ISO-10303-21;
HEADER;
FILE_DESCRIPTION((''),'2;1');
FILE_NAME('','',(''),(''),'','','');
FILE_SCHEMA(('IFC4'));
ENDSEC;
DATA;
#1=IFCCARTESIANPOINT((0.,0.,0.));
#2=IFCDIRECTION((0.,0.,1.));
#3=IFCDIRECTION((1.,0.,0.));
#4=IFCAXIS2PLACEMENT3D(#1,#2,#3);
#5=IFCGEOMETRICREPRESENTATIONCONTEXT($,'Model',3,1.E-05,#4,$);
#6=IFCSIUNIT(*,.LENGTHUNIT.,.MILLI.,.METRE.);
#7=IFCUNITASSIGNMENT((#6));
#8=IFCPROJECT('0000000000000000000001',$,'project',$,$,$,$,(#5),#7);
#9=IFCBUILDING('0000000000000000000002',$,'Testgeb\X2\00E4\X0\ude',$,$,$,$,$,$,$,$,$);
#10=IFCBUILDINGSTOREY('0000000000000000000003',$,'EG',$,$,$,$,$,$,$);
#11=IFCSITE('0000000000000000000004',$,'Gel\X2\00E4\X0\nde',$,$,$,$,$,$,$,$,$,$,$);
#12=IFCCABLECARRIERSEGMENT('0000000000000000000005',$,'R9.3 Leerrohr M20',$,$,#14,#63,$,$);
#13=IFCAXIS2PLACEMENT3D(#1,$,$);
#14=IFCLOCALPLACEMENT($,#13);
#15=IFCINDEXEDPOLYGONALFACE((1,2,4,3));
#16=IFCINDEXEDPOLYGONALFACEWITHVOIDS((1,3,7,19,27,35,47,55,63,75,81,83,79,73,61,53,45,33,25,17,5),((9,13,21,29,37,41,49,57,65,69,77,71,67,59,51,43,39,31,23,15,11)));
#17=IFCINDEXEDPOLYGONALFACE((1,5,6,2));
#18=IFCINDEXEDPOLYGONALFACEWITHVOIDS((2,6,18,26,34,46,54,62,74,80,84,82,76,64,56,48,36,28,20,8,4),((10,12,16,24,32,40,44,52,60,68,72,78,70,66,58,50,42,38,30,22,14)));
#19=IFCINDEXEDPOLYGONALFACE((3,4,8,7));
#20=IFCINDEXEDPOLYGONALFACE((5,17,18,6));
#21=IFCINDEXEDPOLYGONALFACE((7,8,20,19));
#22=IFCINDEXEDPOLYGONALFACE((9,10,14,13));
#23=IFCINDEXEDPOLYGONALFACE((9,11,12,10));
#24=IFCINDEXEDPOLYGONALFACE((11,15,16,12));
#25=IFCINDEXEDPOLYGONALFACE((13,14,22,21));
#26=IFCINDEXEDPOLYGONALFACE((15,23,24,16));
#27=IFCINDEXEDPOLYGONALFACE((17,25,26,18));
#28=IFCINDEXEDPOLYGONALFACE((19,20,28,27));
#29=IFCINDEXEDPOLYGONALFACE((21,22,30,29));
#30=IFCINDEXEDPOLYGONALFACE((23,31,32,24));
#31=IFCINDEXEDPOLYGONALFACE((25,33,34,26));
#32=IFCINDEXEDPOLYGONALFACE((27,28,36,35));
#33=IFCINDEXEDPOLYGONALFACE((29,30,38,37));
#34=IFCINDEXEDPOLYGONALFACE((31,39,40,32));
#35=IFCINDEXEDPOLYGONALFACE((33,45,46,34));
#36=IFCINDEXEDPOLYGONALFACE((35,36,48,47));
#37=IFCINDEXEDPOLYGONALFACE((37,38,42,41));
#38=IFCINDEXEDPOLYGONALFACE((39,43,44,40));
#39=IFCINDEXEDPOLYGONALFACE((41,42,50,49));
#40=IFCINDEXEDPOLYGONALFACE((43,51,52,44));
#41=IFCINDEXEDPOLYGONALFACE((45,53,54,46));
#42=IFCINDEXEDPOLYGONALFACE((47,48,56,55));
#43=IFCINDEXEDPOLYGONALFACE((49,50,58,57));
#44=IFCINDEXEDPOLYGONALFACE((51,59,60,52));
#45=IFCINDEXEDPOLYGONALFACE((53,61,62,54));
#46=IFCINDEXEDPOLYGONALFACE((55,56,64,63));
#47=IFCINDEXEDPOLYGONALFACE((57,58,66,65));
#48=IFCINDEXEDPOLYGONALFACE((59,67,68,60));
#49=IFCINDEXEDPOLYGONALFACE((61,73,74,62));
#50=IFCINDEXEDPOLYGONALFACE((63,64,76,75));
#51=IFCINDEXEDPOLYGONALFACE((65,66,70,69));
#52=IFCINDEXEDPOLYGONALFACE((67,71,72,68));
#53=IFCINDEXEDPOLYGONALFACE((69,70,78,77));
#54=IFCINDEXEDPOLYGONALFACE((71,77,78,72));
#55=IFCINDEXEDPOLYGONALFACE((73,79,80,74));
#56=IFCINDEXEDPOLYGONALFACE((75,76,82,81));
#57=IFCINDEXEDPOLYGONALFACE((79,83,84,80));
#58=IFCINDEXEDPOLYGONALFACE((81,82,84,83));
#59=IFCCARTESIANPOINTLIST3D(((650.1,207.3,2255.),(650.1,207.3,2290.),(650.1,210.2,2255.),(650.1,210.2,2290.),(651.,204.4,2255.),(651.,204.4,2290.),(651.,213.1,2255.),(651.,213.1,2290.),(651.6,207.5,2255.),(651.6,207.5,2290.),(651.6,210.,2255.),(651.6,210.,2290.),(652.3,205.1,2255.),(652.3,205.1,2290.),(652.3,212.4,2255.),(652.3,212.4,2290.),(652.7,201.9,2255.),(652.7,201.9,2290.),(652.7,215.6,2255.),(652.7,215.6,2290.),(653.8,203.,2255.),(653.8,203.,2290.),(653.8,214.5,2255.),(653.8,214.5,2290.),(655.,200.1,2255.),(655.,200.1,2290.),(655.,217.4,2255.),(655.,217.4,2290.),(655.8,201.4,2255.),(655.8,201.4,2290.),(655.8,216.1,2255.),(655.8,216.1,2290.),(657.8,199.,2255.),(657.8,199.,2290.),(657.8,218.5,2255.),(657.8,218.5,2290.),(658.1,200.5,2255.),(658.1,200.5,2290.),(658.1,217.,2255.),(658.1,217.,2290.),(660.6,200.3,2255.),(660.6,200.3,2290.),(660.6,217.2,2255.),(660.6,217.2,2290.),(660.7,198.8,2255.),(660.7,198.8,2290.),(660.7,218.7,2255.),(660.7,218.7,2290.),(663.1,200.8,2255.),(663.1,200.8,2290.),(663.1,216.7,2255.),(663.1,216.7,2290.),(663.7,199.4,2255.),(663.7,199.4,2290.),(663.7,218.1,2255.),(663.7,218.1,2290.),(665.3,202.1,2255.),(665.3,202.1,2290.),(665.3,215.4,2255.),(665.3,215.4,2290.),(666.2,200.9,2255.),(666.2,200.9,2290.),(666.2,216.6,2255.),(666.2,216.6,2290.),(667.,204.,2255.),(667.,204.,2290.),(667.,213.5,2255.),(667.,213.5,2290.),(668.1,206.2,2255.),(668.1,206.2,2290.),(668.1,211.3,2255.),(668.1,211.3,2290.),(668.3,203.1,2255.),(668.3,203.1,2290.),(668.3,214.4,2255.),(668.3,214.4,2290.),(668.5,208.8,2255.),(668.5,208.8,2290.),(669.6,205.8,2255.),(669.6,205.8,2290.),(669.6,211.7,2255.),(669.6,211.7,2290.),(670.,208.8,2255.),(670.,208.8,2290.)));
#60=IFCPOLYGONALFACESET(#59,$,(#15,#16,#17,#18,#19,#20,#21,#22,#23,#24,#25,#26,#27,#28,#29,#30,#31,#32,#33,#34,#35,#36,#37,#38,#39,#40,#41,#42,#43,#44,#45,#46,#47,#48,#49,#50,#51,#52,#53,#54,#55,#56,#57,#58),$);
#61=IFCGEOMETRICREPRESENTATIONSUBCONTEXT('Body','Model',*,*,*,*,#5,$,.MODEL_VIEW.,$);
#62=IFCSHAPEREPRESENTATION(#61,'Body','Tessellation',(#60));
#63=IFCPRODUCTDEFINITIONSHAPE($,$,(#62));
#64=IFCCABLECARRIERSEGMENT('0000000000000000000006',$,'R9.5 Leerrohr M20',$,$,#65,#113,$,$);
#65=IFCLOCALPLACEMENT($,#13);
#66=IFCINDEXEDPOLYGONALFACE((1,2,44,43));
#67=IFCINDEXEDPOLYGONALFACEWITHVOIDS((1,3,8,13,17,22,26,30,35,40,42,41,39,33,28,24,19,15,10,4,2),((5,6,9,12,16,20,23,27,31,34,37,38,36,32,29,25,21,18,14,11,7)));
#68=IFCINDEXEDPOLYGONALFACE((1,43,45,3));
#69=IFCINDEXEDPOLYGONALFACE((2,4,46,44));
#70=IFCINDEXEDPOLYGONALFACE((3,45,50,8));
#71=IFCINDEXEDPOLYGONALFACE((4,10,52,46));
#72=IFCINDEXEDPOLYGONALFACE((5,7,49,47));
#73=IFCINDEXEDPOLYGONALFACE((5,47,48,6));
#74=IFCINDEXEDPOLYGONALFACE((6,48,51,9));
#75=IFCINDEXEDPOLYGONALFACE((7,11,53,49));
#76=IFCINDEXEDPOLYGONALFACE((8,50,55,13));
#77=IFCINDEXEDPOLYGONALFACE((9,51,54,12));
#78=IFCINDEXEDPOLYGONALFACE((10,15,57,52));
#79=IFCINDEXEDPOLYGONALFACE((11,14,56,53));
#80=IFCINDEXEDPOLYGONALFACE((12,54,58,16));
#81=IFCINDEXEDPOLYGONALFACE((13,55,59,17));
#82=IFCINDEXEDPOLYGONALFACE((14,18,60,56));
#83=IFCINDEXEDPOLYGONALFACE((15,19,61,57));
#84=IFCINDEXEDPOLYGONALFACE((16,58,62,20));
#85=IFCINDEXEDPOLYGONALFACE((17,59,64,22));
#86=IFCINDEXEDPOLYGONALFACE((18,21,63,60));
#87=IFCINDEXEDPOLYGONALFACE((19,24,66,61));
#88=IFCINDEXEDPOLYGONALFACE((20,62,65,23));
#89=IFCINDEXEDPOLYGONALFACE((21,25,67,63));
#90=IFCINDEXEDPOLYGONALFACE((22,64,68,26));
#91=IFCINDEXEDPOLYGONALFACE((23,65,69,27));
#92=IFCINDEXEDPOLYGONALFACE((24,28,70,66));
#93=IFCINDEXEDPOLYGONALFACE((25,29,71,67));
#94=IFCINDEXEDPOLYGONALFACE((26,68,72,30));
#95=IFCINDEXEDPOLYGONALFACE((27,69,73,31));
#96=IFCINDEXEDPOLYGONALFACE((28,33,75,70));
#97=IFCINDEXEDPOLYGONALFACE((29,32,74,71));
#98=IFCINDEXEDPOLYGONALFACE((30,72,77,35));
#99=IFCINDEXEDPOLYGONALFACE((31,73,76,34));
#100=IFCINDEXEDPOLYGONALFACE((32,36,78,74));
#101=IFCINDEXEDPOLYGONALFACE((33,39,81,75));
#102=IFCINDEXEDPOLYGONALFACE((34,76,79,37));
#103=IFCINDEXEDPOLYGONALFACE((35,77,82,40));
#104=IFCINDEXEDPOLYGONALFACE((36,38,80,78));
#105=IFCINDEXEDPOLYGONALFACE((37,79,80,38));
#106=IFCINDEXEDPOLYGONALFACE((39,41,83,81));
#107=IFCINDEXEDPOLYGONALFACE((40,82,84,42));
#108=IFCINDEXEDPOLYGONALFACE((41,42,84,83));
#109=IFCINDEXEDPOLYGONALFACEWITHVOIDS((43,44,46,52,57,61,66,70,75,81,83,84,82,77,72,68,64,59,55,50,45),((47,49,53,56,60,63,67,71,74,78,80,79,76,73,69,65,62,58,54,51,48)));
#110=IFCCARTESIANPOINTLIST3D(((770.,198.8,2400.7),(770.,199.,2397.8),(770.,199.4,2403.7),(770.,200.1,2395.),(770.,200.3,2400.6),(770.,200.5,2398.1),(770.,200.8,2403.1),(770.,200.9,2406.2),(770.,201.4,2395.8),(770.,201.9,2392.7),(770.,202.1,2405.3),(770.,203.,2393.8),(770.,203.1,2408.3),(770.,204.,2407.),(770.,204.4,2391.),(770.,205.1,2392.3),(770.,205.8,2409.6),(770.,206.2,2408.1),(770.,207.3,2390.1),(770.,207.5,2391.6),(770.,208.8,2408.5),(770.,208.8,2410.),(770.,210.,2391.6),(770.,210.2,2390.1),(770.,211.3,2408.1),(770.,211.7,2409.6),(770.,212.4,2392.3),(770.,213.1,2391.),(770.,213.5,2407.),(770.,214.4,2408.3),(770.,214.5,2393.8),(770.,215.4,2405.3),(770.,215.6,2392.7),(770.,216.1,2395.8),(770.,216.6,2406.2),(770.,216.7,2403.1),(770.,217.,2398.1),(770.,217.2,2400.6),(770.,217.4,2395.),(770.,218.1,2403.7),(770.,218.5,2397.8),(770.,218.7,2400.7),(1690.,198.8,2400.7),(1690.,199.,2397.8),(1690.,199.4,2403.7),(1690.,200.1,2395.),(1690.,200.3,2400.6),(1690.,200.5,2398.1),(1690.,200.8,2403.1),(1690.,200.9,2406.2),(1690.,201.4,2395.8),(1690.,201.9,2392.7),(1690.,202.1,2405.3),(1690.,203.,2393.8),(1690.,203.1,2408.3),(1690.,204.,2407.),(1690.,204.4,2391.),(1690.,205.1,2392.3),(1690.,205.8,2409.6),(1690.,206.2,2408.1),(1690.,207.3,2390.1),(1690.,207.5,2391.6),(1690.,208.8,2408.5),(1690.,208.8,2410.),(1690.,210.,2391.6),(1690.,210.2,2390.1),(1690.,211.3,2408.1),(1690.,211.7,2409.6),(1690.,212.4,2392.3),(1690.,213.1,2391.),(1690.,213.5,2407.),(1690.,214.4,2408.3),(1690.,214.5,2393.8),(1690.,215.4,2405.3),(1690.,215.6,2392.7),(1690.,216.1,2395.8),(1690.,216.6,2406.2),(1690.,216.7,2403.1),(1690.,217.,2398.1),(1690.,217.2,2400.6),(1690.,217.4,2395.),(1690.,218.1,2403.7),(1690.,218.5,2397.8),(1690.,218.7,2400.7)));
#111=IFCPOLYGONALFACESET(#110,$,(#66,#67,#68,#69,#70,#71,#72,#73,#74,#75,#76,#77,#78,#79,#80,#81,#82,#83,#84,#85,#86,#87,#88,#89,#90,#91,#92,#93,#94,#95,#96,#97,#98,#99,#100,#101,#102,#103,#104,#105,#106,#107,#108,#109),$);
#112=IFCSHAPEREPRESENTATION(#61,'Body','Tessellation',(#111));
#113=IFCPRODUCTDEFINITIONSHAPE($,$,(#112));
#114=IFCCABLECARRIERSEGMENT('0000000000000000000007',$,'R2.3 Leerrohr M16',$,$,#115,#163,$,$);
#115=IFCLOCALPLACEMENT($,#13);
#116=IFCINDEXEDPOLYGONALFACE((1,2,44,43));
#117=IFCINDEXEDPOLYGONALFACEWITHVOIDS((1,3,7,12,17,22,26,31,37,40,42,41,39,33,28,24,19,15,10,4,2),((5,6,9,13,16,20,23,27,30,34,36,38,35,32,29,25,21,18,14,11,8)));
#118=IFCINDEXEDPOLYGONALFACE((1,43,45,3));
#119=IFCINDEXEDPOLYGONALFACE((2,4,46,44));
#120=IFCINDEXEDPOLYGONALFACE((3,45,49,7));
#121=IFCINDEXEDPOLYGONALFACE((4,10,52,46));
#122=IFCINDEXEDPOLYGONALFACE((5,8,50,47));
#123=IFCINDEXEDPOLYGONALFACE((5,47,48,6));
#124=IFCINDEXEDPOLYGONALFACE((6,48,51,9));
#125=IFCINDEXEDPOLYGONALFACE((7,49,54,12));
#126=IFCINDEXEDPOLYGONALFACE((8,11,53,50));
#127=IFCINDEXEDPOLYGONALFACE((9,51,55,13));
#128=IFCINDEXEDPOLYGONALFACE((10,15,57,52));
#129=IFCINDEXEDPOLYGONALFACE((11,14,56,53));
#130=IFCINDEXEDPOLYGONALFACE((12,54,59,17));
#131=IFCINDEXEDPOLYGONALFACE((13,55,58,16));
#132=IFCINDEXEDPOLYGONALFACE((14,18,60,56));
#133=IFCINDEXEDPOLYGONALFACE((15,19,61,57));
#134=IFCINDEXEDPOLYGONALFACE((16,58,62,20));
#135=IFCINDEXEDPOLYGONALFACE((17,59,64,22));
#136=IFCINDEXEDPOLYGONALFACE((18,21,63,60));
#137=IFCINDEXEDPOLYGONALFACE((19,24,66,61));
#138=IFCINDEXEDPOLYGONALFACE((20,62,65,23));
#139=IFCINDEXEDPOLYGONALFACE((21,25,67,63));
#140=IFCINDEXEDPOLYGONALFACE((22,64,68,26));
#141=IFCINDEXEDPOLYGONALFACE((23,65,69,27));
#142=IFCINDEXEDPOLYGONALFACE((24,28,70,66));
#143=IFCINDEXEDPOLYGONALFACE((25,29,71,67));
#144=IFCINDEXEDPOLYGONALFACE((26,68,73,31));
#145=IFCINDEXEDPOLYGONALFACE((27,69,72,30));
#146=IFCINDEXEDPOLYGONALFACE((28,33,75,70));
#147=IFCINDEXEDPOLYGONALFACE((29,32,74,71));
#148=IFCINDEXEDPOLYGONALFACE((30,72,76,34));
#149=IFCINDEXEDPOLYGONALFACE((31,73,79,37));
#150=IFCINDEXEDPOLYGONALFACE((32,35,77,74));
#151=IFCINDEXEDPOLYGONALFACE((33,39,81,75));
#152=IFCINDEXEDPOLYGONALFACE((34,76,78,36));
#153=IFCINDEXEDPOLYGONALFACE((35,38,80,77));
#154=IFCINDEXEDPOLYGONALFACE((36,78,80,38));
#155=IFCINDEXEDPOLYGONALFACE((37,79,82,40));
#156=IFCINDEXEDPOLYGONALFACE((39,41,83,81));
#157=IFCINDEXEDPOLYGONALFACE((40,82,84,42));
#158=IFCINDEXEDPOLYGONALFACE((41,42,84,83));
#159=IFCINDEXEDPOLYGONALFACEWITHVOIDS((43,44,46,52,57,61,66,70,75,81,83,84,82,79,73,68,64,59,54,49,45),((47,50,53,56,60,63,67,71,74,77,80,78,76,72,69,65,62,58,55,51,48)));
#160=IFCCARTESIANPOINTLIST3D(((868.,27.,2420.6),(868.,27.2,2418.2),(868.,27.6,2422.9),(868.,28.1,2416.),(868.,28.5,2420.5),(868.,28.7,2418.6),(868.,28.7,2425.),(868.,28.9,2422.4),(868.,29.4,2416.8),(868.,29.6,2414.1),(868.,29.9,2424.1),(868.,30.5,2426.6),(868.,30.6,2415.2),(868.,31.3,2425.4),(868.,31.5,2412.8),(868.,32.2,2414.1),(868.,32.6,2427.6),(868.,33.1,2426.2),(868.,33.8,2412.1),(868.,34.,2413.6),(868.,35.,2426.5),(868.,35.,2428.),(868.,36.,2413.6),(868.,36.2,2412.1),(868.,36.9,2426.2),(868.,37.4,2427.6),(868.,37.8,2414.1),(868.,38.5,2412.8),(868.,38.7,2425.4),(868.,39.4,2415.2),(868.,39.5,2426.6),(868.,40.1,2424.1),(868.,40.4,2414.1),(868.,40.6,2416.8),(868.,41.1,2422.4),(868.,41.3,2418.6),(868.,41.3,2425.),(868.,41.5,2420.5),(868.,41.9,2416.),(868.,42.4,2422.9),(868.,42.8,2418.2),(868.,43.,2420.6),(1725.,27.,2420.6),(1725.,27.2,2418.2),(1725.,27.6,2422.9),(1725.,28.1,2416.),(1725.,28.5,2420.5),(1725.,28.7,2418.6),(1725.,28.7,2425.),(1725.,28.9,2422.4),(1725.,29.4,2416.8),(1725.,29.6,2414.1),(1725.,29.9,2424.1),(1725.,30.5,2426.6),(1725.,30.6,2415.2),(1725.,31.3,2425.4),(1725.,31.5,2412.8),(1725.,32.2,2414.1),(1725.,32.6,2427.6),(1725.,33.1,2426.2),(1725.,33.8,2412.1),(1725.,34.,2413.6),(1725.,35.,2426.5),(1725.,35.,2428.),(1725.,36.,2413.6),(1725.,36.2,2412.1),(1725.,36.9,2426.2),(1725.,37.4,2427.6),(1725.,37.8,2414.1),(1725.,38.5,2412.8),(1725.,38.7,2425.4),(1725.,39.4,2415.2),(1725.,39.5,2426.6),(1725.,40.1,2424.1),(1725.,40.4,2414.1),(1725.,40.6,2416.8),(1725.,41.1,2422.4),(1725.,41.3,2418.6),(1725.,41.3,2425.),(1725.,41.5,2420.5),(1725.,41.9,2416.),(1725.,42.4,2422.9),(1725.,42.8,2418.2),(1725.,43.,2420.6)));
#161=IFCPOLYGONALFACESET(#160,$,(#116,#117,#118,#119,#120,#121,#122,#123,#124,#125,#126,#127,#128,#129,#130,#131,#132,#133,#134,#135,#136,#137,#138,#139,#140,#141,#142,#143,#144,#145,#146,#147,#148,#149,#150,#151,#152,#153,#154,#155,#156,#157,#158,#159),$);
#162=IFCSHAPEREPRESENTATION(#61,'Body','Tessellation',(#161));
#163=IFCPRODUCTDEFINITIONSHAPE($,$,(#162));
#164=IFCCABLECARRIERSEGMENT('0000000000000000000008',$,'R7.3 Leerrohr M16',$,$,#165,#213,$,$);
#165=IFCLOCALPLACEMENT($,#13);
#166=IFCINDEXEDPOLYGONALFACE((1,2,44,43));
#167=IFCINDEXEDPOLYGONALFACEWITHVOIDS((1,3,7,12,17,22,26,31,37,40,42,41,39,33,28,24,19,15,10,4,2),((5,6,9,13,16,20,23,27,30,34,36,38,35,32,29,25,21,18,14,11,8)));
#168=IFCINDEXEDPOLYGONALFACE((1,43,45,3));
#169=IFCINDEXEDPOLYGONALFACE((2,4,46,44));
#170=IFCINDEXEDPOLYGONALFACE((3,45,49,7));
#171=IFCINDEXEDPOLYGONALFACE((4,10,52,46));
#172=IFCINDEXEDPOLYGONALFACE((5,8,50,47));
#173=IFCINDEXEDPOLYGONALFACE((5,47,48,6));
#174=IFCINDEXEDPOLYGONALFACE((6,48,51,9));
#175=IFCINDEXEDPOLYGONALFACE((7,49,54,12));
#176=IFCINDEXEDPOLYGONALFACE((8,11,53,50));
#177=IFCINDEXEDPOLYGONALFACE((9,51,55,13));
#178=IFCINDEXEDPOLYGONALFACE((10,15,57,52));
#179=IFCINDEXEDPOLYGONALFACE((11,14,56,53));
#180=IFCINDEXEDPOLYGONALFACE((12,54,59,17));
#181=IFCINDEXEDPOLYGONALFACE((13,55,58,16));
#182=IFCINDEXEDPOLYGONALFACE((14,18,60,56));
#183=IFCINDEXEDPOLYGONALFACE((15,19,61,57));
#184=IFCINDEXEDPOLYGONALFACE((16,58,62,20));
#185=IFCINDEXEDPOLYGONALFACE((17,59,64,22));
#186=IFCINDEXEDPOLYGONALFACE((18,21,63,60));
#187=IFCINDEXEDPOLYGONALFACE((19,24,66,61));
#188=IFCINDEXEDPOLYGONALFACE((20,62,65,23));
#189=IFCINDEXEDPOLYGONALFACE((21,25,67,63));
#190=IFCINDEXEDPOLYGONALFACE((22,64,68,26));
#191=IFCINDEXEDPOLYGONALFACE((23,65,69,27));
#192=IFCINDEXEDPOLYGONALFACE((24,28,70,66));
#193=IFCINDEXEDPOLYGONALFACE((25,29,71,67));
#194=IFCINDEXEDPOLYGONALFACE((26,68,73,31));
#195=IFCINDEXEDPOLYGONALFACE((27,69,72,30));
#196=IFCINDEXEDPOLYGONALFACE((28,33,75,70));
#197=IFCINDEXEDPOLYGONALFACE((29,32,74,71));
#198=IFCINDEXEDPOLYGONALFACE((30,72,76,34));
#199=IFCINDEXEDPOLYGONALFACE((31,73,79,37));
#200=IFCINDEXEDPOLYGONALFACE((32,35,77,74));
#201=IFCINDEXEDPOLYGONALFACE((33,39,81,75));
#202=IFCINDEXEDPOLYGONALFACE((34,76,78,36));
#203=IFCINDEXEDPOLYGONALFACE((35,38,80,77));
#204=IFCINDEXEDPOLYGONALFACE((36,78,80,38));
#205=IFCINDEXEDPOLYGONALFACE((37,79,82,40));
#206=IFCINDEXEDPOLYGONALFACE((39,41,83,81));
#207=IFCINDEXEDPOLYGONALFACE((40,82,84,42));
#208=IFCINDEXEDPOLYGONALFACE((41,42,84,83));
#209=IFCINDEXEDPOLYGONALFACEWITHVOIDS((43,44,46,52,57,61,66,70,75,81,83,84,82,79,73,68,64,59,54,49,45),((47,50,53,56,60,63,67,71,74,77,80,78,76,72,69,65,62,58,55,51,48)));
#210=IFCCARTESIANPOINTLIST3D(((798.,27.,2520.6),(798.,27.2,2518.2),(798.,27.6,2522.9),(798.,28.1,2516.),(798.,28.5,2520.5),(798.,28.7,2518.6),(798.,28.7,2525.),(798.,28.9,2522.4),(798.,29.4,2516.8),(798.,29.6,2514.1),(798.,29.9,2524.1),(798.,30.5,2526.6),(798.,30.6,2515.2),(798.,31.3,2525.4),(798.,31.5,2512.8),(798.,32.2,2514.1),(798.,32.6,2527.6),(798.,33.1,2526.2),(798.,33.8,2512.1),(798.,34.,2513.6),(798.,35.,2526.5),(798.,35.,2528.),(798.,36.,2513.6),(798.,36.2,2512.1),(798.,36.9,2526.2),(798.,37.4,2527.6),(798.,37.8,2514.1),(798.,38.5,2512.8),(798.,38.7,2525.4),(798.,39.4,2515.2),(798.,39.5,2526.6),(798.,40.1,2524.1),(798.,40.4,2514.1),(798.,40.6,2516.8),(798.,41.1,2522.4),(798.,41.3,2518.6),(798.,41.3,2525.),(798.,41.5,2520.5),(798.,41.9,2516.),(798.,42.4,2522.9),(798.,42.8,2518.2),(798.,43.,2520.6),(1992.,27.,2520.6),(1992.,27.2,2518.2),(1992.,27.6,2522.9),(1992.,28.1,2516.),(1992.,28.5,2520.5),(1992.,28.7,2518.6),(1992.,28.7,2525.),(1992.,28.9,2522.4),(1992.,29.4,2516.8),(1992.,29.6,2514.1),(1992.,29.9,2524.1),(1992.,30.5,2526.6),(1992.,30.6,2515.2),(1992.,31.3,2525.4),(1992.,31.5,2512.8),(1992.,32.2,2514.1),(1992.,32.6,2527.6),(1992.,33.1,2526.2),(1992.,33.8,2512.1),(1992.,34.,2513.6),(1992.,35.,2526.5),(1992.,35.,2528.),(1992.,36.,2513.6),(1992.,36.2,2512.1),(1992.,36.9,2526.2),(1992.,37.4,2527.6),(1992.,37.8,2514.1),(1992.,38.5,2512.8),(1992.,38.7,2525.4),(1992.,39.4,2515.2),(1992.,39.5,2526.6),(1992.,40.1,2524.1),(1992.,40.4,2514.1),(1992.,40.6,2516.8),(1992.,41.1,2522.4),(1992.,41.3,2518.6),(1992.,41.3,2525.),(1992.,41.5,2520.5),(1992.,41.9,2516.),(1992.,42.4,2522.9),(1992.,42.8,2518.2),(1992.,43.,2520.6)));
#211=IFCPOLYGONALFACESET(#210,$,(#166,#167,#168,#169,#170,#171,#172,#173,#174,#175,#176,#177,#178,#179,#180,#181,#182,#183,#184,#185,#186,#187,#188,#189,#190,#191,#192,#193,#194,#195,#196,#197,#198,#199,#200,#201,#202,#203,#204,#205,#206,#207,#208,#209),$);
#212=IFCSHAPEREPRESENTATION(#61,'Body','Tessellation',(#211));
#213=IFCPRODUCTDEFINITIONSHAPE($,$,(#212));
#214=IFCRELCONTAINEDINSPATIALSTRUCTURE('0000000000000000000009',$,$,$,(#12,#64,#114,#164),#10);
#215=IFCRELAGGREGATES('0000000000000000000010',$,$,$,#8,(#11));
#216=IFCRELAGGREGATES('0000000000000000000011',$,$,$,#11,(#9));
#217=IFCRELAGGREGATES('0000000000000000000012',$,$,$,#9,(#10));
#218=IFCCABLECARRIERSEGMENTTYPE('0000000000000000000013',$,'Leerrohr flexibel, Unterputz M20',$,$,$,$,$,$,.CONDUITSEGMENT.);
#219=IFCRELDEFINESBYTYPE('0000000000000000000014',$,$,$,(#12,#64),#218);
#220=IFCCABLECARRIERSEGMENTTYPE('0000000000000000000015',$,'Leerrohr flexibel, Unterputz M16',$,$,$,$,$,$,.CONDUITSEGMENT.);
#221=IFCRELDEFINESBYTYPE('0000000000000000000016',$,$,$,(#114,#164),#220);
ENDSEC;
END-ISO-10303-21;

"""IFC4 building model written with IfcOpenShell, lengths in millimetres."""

from ifc_helpers import new_model, si_unit, frame, origin_with_axes, place, context, subcontext, project, spatial, hollow_circle, extrude, type_object, element, save


model = new_model("IFC4")

# Units and contexts
model_context = context("Model", 3, precision=1e-05, world=origin_with_axes())
body_context = subcontext(model_context, "Body", "Model", "MODEL_VIEW")
ifc_project = project(units=[si_unit("LENGTHUNIT", "METRE", prefix="MILLI")], contexts=[model_context])

# Site, building, storey
site = spatial("IfcSite", under=ifc_project, Name="Gelände")
building = spatial("IfcBuilding", under=site, Name="Testgebäude")
storey = spatial("IfcBuildingStorey", under=building, Name="EG")

# Cable carrier segments
cable_carrier_segment_type_1 = type_object("IfcCableCarrierSegmentType", Name="Leerrohr flexibel, Unterputz M20", PredefinedType="CONDUITSEGMENT")
cable_carrier_segment_1_placement = place(None, frame((660.0, 208.8, 2255.0), z_axis=(0.0, 0.0, 1.0), x_axis=(1.0, 0.0, 0.0)))
element("IfcCableCarrierSegment", 1, at=cable_carrier_segment_1_placement, inside=storey, type_object=cable_carrier_segment_type_1, Name="R9.3 Leerrohr M20", context=body_context, shape_type="SweptSolid", body=[
    extrude(hollow_circle(Radius=10.0, WallThickness=1.5), None, (0.0, 0.0, 1.0), 35.0),
])
cable_carrier_segment_2_placement = place(None, frame((770.0, 208.8, 2400.0), z_axis=(1.0, 0.0, 0.0), x_axis=(0.0, 0.0, 1.0)))
element("IfcCableCarrierSegment", 2, at=cable_carrier_segment_2_placement, inside=storey, type_object=cable_carrier_segment_type_1, Name="R9.5 Leerrohr M20", context=body_context, shape_type="SweptSolid", body=[
    extrude(hollow_circle(Radius=10.0, WallThickness=1.5), None, (0.0, 0.0, 1.0), 920.0),
])

# Cable carrier segments
cable_carrier_segment_type_2 = type_object("IfcCableCarrierSegmentType", Name="Leerrohr flexibel, Unterputz M16", PredefinedType="CONDUITSEGMENT")
cable_carrier_segment_3_placement = place(None, frame((868.0, 35.0, 2420.0), z_axis=(1.0, 0.0, 0.0), x_axis=(0.0, 0.0, 1.0)))
element("IfcCableCarrierSegment", 3, at=cable_carrier_segment_3_placement, inside=storey, type_object=cable_carrier_segment_type_2, Name="R2.3 Leerrohr M16", context=body_context, shape_type="SweptSolid", body=[
    extrude(hollow_circle(Radius=8.0, WallThickness=1.5), None, (0.0, 0.0, 1.0), 857.0),
])
cable_carrier_segment_4_placement = place(None, frame((798.0, 35.0, 2520.0), z_axis=(1.0, 0.0, 0.0), x_axis=(0.0, 0.0, 1.0)))
element("IfcCableCarrierSegment", 4, at=cable_carrier_segment_4_placement, inside=storey, type_object=cable_carrier_segment_type_2, Name="R7.3 Leerrohr M16", context=body_context, shape_type="SweptSolid", body=[
    extrude(hollow_circle(Radius=8.0, WallThickness=1.5), None, (0.0, 0.0, 1.0), 1194.0),
])

save(model, "model.ifc")
